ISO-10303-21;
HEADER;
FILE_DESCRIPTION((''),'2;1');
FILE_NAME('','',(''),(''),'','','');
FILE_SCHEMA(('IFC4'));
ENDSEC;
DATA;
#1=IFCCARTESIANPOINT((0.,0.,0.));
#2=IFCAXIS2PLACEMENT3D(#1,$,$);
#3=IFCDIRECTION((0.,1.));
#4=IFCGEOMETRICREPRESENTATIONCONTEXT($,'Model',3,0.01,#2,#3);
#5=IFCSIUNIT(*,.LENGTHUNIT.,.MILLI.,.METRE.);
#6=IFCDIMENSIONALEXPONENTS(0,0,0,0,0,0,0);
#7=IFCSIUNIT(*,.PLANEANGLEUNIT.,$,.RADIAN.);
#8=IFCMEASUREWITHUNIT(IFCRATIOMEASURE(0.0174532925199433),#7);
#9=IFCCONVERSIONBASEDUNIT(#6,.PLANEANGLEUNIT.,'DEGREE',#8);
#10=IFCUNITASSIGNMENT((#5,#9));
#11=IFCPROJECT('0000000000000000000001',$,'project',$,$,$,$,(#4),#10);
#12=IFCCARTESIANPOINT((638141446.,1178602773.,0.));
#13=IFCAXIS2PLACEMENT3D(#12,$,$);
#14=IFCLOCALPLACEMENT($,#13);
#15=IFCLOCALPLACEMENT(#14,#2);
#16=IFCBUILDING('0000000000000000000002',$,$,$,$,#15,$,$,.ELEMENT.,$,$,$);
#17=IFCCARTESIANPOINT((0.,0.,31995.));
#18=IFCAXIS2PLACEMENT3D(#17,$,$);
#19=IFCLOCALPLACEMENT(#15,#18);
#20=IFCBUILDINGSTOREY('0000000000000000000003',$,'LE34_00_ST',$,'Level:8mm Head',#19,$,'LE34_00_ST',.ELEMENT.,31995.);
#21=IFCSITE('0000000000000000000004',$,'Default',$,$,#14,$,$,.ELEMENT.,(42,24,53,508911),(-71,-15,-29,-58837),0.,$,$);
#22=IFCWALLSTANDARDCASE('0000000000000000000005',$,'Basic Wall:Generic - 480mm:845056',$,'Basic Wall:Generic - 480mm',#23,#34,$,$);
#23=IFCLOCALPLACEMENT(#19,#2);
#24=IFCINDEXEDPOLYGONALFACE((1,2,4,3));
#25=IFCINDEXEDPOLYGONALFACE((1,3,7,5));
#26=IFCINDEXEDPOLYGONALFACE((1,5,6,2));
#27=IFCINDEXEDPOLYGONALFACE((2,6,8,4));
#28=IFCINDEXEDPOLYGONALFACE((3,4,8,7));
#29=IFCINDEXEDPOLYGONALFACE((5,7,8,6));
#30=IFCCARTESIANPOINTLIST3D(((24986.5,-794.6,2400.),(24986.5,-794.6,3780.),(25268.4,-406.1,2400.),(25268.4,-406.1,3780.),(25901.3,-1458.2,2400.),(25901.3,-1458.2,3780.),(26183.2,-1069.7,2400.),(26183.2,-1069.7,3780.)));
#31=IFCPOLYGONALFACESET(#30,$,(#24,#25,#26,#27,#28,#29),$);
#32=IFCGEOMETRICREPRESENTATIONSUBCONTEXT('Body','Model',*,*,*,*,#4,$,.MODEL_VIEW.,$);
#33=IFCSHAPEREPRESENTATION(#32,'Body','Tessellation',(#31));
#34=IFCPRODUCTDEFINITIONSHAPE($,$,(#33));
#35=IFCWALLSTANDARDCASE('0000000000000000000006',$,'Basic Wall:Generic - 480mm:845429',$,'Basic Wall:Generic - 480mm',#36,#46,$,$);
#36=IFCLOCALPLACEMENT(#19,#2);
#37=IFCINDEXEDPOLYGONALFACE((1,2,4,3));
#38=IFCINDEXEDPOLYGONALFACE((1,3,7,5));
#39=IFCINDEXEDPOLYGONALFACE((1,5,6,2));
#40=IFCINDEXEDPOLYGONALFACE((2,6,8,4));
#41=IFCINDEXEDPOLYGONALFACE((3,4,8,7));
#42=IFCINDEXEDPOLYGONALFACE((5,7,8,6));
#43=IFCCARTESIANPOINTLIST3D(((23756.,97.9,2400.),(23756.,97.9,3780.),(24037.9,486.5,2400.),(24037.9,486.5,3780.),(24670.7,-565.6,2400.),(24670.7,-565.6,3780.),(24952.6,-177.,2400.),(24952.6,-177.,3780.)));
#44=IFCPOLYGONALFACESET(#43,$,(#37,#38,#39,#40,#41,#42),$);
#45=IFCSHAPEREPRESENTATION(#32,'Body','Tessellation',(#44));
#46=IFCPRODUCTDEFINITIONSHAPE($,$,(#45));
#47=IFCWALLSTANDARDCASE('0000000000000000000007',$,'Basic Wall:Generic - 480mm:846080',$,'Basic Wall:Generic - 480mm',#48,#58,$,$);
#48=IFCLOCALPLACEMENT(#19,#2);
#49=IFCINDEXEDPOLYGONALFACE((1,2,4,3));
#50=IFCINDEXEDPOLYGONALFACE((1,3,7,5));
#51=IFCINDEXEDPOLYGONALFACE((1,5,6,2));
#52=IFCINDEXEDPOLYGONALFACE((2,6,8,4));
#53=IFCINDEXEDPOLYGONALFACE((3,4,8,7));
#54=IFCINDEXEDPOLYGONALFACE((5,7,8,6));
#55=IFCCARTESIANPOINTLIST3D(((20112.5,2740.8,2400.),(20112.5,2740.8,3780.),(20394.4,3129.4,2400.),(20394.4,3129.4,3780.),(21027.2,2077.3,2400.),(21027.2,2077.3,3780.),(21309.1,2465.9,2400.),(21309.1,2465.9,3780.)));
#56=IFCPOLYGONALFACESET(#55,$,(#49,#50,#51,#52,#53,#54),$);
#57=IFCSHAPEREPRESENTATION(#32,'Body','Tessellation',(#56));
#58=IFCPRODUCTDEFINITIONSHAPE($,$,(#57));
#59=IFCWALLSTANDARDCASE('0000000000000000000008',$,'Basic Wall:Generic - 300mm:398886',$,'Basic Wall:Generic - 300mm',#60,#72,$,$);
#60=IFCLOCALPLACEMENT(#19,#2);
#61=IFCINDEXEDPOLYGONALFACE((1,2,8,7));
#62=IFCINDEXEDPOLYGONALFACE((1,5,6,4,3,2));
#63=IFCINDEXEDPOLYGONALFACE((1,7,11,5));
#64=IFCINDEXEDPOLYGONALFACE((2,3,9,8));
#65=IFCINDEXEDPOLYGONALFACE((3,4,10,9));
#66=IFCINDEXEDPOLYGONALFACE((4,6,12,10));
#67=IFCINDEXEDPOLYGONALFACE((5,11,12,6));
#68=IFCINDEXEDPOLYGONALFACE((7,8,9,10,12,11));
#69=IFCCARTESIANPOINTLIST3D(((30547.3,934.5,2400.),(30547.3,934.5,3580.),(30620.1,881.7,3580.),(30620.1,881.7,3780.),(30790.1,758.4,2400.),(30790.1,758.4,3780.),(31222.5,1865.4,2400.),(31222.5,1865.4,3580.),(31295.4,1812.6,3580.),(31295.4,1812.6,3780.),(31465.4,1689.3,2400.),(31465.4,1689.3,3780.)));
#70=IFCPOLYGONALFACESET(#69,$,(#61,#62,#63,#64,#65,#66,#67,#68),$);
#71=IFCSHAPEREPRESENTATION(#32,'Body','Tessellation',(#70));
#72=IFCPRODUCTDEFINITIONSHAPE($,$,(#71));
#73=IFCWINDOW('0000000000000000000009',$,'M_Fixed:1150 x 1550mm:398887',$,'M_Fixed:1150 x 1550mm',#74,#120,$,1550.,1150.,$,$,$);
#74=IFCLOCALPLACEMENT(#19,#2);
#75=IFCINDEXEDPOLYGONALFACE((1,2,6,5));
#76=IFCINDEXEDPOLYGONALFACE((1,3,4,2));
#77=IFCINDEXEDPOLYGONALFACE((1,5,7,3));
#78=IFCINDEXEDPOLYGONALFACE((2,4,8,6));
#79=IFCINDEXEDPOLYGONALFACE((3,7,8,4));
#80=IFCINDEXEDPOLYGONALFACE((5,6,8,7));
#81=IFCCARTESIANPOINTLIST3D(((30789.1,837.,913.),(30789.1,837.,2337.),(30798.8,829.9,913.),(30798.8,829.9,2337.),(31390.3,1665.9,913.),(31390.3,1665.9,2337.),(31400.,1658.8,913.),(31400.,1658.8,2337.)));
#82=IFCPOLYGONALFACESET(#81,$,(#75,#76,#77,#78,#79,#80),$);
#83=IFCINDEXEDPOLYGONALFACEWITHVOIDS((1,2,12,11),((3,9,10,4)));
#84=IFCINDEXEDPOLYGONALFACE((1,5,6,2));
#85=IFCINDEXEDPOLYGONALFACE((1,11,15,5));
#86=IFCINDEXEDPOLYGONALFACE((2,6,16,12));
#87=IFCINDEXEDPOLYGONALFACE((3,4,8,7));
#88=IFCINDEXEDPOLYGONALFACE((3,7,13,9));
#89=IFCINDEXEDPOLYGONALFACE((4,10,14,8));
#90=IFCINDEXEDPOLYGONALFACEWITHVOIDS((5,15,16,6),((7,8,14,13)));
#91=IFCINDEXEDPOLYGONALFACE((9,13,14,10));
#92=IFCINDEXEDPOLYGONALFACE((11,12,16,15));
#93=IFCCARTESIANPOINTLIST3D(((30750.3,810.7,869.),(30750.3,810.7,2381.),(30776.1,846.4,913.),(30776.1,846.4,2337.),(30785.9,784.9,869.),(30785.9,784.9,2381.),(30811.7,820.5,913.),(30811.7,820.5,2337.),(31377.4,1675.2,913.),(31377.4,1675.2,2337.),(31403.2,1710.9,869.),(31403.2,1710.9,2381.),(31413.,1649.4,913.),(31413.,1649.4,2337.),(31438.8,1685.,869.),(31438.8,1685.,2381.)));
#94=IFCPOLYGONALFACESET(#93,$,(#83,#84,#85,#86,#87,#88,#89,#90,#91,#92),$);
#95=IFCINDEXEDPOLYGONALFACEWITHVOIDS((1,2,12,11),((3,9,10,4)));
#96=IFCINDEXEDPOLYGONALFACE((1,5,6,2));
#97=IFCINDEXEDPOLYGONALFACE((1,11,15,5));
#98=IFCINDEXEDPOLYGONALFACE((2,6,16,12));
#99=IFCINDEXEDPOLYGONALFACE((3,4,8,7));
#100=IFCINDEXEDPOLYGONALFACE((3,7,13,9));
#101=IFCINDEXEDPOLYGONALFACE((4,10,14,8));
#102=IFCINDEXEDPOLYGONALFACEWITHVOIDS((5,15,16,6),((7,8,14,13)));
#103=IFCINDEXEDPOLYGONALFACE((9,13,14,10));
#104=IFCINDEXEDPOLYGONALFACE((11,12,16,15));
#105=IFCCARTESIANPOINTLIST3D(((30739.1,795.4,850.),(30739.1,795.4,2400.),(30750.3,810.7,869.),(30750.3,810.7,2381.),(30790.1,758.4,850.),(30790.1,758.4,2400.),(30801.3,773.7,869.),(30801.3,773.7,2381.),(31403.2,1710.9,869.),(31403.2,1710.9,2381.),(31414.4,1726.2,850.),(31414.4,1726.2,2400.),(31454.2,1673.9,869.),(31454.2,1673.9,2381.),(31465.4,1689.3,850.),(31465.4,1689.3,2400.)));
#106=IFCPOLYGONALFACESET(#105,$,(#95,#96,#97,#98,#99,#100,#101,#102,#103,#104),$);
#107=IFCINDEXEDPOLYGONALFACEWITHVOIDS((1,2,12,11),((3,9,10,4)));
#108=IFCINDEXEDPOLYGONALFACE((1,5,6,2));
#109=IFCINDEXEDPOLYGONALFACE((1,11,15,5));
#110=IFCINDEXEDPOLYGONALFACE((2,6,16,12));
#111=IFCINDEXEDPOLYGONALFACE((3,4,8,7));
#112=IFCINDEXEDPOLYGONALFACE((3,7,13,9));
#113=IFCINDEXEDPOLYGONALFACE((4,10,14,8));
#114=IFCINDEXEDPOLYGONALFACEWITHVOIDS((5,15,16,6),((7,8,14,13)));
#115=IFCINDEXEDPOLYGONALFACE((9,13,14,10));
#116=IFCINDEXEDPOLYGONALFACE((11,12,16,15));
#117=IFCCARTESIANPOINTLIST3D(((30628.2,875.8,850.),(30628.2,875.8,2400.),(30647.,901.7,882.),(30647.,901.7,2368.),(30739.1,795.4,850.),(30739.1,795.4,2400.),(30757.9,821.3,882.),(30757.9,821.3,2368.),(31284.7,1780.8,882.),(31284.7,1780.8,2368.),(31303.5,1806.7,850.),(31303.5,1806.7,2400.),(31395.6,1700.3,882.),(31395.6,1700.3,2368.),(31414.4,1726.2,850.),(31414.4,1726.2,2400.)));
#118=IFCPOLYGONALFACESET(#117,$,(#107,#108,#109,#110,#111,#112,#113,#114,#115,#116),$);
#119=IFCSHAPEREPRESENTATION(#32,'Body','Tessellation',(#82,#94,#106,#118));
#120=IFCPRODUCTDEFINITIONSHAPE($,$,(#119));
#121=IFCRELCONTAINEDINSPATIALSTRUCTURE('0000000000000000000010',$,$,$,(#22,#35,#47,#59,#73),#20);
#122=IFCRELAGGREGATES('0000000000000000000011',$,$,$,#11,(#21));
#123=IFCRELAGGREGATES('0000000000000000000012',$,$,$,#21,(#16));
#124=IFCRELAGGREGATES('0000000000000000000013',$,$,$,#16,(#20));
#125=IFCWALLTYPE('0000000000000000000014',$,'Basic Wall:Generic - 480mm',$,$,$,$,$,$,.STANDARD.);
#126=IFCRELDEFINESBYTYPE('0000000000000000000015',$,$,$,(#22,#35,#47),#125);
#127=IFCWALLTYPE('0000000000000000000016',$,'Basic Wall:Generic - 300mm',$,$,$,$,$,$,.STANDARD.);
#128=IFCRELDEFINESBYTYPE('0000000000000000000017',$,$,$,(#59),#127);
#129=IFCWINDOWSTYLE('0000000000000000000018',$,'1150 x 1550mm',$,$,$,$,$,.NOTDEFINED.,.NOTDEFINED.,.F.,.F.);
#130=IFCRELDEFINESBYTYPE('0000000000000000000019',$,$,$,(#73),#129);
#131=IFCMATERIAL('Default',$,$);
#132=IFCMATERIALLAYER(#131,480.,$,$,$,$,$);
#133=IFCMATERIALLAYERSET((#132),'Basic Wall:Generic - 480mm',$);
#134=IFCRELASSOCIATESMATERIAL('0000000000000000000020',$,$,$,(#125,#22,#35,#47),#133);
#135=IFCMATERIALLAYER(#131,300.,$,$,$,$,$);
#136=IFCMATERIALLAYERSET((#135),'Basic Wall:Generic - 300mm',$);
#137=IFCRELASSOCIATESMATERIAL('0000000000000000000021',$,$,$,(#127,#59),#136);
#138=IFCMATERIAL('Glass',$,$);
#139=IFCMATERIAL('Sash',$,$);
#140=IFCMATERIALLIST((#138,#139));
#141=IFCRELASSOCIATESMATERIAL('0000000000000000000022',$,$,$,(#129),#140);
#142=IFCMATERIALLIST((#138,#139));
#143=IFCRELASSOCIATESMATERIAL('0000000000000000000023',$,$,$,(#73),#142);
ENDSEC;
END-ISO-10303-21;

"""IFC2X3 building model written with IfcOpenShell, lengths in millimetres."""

from ifc_helpers import new_model, entity, si_unit, converted_unit, direction, frame, frame_2d, origin, place, context, subcontext, project, spatial, polyline, rectangle, outline, extrude, clip, bounded_halfspace, source, transform, mapped, material, material_list, layer, layer_set, layer_usage, type_object, type_shapes, element, fill, save


model = new_model("IFC2X3")

# Units and contexts
model_context = context("Model", 3, precision=0.01, world=origin(), true_north=direction((0.0, 1.0)))
body_context = subcontext(model_context, "Body", "Model", "MODEL_VIEW")
ifc_project = project(units=[si_unit("LENGTHUNIT", "METRE", prefix="MILLI"), converted_unit("PLANEANGLEUNIT", "DEGREE", entity("IfcRatioMeasure", 0.0174532925199433), si_unit("PLANEANGLEUNIT", "RADIAN"), dimensions=[0, 0, 0, 0, 0, 0, 0])], contexts=[model_context])

# Site, building, storey
site_placement = place(None, frame((638141446.0, 1178602773.0, 0.0)))
site = spatial("IfcSite", under=ifc_project, at=site_placement, Name="Default", CompositionType="ELEMENT", RefLatitude=(42, 24, 53, 508911), RefLongitude=(-71, -15, -29, -58837), RefElevation=0.0)
building_placement = place(site_placement, origin())
building = spatial("IfcBuilding", under=site, at=building_placement, CompositionType="ELEMENT")
storey_placement = place(building_placement, frame((0.0, 0.0, 31995.0)))
storey = spatial("IfcBuildingStorey", under=building, at=storey_placement, Name="LE34_00_ST", ObjectType="Level:8mm Head", LongName="LE34_00_ST", CompositionType="ELEMENT", Elevation=31995.0)

# Walls
ifc_material_1 = material(Name="Default")
ifc_layer_1 = layer(ifc_material_1, 480.0)
ifc_layer_set_1 = layer_set([ifc_layer_1], Name="Basic Wall:Generic - 480mm")
ifc_layer_usage_1 = layer_usage(ifc_layer_set_1, "AXIS2", "NEGATIVE", 240.0)
wall_type_1 = type_object("IfcWallType", Name="Basic Wall:Generic - 480mm", PredefinedType="STANDARD", material=ifc_layer_set_1)
wall_1_placement = place(storey_placement, frame((26042.3, -1264.0, 2400.0), z_axis=(0.0, 0.0, 1.0), x_axis=(-0.809468, 0.587164, 0.0)))
element("IfcWallStandardCase", 1, at=wall_1_placement, inside=storey, type_object=wall_type_1, material=ifc_layer_usage_1, Name="Basic Wall:Generic - 480mm:845056", ObjectType="Basic Wall:Generic - 480mm", context=body_context, shape_type="SweptSolid", body=[
    extrude(rectangle(XDim=1130.1, YDim=480.0, at=frame_2d((565.1, 0.0), x_axis=(-1.0, 0.0))), origin(), (0.0, 0.0, 1.0), 1380.0),
])
ifc_layer_usage_2 = layer_usage(ifc_layer_set_1, "AXIS2", "NEGATIVE", 240.0)
wall_2_placement = place(storey_placement, frame((24811.6, -371.3, 2400.0), z_axis=(0.0, 0.0, 1.0), x_axis=(-0.809468, 0.587164, 0.0)))
element("IfcWallStandardCase", 2, at=wall_2_placement, inside=storey, type_object=wall_type_1, material=ifc_layer_usage_2, Name="Basic Wall:Generic - 480mm:845429", ObjectType="Basic Wall:Generic - 480mm", context=body_context, shape_type="SweptSolid", body=[
    extrude(rectangle(XDim=1130.0, YDim=480.0, at=frame_2d((565.0, 0.0), x_axis=(-1.0, 0.0))), origin(), (0.0, 0.0, 1.0), 1380.0),
])
ifc_layer_usage_3 = layer_usage(ifc_layer_set_1, "AXIS2", "NEGATIVE", 240.0)
wall_3_placement = place(storey_placement, frame((21168.1, 2271.6, 2400.0), z_axis=(0.0, 0.0, 1.0), x_axis=(-0.809468, 0.587164, 0.0)))
element("IfcWallStandardCase", 3, at=wall_3_placement, inside=storey, type_object=wall_type_1, material=ifc_layer_usage_3, Name="Basic Wall:Generic - 480mm:846080", ObjectType="Basic Wall:Generic - 480mm", context=body_context, shape_type="SweptSolid", body=[
    extrude(rectangle(XDim=1130.0, YDim=480.0, at=frame_2d((565.0, 0.0), x_axis=(-1.0, 0.0))), origin(), (0.0, 0.0, 1.0), 1380.0),
])

# Wall, opening, window
ifc_layer_2 = layer(ifc_material_1, 300.0)
ifc_layer_set_2 = layer_set([ifc_layer_2], Name="Basic Wall:Generic - 300mm")
ifc_layer_usage_4 = layer_usage(ifc_layer_set_2, "AXIS2", "POSITIVE", -150.0)
wall_type_2 = type_object("IfcWallType", Name="Basic Wall:Generic - 300mm", PredefinedType="STANDARD", material=ifc_layer_set_2)
wall_4_placement = place(storey_placement, frame((30668.7, 846.4, 2400.0), z_axis=(0.0, 0.0, 1.0), x_axis=(0.587164, 0.809468, 0.0)))
wall_4 = element("IfcWallStandardCase", 4, at=wall_4_placement, inside=storey, type_object=wall_type_2, material=ifc_layer_usage_4, Name="Basic Wall:Generic - 300mm:398886", ObjectType="Basic Wall:Generic - 300mm", context=body_context, shape_type="Clipping", body=[
    clip(clip(extrude(rectangle(XDim=1150.0, YDim=300.0, at=frame_2d((575.0, 0.0), x_axis=(-1.0, 0.0))), origin(), (0.0, 0.0, 1.0), 1380.0), bounded_halfspace(frame((0.0, 60.0, 1180.0), z_axis=(0.0, 0.0, -1.0), x_axis=(0.0, 1.0, 0.0)), True, frame((0.0, 60.0, 1180.0), z_axis=(0.0, 0.0, -1.0), x_axis=(0.0, 1.0, 0.0)), polyline([(0.0, 0.0), (90.0, 0.0), (90.0, 1150.0), (0.0, 1150.0), (0.0, 0.0)]))), bounded_halfspace(frame((1150.0, 60.0, 1180.0), z_axis=(0.0, -1.0, 0.0), x_axis=(0.0, 0.0, 1.0)), True, frame((1150.0, 60.0, 1180.0), z_axis=(0.0, -1.0, 0.0), x_axis=(0.0, 0.0, 1.0)), polyline([(0.0, 0.0), (200.0, 0.0), (200.0, 1150.0), (0.0, 1150.0), (0.0, 0.0)]))),
])
opening_1_placement = place(wall_4_placement, frame((1150.0, 150.0, -1550.0)))
opening_1 = element("IfcOpeningElement", 5, at=opening_1_placement, cuts=wall_4, ObjectType="Opening", context=body_context, shape_type="SweptSolid", body=[
    extrude(rectangle(XDim=1550.0, YDim=1150.0, at=frame_2d((775.0, 575.0), x_axis=(1.0, 0.0))), frame((0.0, 0.0, 0.0), z_axis=(0.0, -1.0, 0.0), x_axis=(0.0, 0.0, 1.0)), (0.0, 0.0, 1.0), 300.0),
])
ifc_material_2 = material(Name="Glass")
ifc_material_3 = material(Name="Sash")
ifc_material_list_1 = material_list([ifc_material_2, ifc_material_3])
ifc_material_list_2 = material_list([ifc_material_2, ifc_material_3])
window_style = type_object("IfcWindowStyle", Name="1150 x 1550mm", ConstructionType="NOTDEFINED", OperationType="NOTDEFINED", ParameterTakesPrecedence=False, Sizeable=False, material=ifc_material_list_2)
shared_shape_1 = source(origin(), body_context, "Body", "SweptSolid", [
    extrude(rectangle(XDim=1024.0, YDim=12.0, at=frame_2d((0.0, 0.0), x_axis=(1.0, 0.0))), frame((575.0, 285.0, 63.0), z_axis=(0.0, 0.0, 1.0), x_axis=(-1.0, 0.0, 0.0)), (0.0, 0.0, 1.0), 1424.0),
    extrude(outline(polyline([(-556.0, -756.0), (556.0, -756.0), (556.0, 756.0), (-556.0, 756.0), (-556.0, -756.0)]), holes=[polyline([(-512.0, -712.0), (-512.0, 712.0), (512.0, 712.0), (512.0, -712.0), (-512.0, -712.0)])]), frame((575.0, 307.0, 775.0), z_axis=(0.0, -1.0, 0.0), x_axis=(-1.0, 0.0, 0.0)), (0.0, 0.0, 1.0), 44.0),
    extrude(outline(polyline([(-575.0, -775.0), (575.0, -775.0), (575.0, 775.0), (-575.0, 775.0), (-575.0, -775.0)]), holes=[polyline([(-556.0, -756.0), (-556.0, 756.0), (556.0, 756.0), (556.0, -756.0), (-556.0, -756.0)])]), frame((575.0, 326.0, 775.0), z_axis=(0.0, -1.0, 0.0), x_axis=(-1.0, 0.0, 0.0)), (0.0, 0.0, 1.0), 63.0),
    extrude(outline(polyline([(-575.0, -775.0), (575.0, -775.0), (575.0, 775.0), (-575.0, 775.0), (-575.0, -775.0)]), holes=[polyline([(-543.0, -743.0), (-543.0, 743.0), (543.0, 743.0), (543.0, -743.0), (-543.0, -743.0)])]), frame((575.0, 263.0, 775.0), z_axis=(0.0, -1.0, 0.0), x_axis=(-1.0, 0.0, 0.0)), (0.0, 0.0, 1.0), 137.0),
])
type_shapes(window_style, [shared_shape_1])
window_1_placement = place(opening_1_placement, frame((0.0, 26.0, 0.0), z_axis=(0.0, 0.0, 1.0), x_axis=(-1.0, 0.0, 0.0)))
window_1 = element("IfcWindow", 6, at=window_1_placement, inside=storey, type_object=window_style, material=ifc_material_list_1, Name="M_Fixed:1150 x 1550mm:398887", ObjectType="M_Fixed:1150 x 1550mm", OverallHeight=1550.0, OverallWidth=1150.0, context=body_context, shape_type="MappedRepresentation", body=[
    mapped(shared_shape_1, transform((0.0, 0.0, 0.0), scale=1.0)),
])
fill(opening_1, window_1)

save(model, "model.ifc")
